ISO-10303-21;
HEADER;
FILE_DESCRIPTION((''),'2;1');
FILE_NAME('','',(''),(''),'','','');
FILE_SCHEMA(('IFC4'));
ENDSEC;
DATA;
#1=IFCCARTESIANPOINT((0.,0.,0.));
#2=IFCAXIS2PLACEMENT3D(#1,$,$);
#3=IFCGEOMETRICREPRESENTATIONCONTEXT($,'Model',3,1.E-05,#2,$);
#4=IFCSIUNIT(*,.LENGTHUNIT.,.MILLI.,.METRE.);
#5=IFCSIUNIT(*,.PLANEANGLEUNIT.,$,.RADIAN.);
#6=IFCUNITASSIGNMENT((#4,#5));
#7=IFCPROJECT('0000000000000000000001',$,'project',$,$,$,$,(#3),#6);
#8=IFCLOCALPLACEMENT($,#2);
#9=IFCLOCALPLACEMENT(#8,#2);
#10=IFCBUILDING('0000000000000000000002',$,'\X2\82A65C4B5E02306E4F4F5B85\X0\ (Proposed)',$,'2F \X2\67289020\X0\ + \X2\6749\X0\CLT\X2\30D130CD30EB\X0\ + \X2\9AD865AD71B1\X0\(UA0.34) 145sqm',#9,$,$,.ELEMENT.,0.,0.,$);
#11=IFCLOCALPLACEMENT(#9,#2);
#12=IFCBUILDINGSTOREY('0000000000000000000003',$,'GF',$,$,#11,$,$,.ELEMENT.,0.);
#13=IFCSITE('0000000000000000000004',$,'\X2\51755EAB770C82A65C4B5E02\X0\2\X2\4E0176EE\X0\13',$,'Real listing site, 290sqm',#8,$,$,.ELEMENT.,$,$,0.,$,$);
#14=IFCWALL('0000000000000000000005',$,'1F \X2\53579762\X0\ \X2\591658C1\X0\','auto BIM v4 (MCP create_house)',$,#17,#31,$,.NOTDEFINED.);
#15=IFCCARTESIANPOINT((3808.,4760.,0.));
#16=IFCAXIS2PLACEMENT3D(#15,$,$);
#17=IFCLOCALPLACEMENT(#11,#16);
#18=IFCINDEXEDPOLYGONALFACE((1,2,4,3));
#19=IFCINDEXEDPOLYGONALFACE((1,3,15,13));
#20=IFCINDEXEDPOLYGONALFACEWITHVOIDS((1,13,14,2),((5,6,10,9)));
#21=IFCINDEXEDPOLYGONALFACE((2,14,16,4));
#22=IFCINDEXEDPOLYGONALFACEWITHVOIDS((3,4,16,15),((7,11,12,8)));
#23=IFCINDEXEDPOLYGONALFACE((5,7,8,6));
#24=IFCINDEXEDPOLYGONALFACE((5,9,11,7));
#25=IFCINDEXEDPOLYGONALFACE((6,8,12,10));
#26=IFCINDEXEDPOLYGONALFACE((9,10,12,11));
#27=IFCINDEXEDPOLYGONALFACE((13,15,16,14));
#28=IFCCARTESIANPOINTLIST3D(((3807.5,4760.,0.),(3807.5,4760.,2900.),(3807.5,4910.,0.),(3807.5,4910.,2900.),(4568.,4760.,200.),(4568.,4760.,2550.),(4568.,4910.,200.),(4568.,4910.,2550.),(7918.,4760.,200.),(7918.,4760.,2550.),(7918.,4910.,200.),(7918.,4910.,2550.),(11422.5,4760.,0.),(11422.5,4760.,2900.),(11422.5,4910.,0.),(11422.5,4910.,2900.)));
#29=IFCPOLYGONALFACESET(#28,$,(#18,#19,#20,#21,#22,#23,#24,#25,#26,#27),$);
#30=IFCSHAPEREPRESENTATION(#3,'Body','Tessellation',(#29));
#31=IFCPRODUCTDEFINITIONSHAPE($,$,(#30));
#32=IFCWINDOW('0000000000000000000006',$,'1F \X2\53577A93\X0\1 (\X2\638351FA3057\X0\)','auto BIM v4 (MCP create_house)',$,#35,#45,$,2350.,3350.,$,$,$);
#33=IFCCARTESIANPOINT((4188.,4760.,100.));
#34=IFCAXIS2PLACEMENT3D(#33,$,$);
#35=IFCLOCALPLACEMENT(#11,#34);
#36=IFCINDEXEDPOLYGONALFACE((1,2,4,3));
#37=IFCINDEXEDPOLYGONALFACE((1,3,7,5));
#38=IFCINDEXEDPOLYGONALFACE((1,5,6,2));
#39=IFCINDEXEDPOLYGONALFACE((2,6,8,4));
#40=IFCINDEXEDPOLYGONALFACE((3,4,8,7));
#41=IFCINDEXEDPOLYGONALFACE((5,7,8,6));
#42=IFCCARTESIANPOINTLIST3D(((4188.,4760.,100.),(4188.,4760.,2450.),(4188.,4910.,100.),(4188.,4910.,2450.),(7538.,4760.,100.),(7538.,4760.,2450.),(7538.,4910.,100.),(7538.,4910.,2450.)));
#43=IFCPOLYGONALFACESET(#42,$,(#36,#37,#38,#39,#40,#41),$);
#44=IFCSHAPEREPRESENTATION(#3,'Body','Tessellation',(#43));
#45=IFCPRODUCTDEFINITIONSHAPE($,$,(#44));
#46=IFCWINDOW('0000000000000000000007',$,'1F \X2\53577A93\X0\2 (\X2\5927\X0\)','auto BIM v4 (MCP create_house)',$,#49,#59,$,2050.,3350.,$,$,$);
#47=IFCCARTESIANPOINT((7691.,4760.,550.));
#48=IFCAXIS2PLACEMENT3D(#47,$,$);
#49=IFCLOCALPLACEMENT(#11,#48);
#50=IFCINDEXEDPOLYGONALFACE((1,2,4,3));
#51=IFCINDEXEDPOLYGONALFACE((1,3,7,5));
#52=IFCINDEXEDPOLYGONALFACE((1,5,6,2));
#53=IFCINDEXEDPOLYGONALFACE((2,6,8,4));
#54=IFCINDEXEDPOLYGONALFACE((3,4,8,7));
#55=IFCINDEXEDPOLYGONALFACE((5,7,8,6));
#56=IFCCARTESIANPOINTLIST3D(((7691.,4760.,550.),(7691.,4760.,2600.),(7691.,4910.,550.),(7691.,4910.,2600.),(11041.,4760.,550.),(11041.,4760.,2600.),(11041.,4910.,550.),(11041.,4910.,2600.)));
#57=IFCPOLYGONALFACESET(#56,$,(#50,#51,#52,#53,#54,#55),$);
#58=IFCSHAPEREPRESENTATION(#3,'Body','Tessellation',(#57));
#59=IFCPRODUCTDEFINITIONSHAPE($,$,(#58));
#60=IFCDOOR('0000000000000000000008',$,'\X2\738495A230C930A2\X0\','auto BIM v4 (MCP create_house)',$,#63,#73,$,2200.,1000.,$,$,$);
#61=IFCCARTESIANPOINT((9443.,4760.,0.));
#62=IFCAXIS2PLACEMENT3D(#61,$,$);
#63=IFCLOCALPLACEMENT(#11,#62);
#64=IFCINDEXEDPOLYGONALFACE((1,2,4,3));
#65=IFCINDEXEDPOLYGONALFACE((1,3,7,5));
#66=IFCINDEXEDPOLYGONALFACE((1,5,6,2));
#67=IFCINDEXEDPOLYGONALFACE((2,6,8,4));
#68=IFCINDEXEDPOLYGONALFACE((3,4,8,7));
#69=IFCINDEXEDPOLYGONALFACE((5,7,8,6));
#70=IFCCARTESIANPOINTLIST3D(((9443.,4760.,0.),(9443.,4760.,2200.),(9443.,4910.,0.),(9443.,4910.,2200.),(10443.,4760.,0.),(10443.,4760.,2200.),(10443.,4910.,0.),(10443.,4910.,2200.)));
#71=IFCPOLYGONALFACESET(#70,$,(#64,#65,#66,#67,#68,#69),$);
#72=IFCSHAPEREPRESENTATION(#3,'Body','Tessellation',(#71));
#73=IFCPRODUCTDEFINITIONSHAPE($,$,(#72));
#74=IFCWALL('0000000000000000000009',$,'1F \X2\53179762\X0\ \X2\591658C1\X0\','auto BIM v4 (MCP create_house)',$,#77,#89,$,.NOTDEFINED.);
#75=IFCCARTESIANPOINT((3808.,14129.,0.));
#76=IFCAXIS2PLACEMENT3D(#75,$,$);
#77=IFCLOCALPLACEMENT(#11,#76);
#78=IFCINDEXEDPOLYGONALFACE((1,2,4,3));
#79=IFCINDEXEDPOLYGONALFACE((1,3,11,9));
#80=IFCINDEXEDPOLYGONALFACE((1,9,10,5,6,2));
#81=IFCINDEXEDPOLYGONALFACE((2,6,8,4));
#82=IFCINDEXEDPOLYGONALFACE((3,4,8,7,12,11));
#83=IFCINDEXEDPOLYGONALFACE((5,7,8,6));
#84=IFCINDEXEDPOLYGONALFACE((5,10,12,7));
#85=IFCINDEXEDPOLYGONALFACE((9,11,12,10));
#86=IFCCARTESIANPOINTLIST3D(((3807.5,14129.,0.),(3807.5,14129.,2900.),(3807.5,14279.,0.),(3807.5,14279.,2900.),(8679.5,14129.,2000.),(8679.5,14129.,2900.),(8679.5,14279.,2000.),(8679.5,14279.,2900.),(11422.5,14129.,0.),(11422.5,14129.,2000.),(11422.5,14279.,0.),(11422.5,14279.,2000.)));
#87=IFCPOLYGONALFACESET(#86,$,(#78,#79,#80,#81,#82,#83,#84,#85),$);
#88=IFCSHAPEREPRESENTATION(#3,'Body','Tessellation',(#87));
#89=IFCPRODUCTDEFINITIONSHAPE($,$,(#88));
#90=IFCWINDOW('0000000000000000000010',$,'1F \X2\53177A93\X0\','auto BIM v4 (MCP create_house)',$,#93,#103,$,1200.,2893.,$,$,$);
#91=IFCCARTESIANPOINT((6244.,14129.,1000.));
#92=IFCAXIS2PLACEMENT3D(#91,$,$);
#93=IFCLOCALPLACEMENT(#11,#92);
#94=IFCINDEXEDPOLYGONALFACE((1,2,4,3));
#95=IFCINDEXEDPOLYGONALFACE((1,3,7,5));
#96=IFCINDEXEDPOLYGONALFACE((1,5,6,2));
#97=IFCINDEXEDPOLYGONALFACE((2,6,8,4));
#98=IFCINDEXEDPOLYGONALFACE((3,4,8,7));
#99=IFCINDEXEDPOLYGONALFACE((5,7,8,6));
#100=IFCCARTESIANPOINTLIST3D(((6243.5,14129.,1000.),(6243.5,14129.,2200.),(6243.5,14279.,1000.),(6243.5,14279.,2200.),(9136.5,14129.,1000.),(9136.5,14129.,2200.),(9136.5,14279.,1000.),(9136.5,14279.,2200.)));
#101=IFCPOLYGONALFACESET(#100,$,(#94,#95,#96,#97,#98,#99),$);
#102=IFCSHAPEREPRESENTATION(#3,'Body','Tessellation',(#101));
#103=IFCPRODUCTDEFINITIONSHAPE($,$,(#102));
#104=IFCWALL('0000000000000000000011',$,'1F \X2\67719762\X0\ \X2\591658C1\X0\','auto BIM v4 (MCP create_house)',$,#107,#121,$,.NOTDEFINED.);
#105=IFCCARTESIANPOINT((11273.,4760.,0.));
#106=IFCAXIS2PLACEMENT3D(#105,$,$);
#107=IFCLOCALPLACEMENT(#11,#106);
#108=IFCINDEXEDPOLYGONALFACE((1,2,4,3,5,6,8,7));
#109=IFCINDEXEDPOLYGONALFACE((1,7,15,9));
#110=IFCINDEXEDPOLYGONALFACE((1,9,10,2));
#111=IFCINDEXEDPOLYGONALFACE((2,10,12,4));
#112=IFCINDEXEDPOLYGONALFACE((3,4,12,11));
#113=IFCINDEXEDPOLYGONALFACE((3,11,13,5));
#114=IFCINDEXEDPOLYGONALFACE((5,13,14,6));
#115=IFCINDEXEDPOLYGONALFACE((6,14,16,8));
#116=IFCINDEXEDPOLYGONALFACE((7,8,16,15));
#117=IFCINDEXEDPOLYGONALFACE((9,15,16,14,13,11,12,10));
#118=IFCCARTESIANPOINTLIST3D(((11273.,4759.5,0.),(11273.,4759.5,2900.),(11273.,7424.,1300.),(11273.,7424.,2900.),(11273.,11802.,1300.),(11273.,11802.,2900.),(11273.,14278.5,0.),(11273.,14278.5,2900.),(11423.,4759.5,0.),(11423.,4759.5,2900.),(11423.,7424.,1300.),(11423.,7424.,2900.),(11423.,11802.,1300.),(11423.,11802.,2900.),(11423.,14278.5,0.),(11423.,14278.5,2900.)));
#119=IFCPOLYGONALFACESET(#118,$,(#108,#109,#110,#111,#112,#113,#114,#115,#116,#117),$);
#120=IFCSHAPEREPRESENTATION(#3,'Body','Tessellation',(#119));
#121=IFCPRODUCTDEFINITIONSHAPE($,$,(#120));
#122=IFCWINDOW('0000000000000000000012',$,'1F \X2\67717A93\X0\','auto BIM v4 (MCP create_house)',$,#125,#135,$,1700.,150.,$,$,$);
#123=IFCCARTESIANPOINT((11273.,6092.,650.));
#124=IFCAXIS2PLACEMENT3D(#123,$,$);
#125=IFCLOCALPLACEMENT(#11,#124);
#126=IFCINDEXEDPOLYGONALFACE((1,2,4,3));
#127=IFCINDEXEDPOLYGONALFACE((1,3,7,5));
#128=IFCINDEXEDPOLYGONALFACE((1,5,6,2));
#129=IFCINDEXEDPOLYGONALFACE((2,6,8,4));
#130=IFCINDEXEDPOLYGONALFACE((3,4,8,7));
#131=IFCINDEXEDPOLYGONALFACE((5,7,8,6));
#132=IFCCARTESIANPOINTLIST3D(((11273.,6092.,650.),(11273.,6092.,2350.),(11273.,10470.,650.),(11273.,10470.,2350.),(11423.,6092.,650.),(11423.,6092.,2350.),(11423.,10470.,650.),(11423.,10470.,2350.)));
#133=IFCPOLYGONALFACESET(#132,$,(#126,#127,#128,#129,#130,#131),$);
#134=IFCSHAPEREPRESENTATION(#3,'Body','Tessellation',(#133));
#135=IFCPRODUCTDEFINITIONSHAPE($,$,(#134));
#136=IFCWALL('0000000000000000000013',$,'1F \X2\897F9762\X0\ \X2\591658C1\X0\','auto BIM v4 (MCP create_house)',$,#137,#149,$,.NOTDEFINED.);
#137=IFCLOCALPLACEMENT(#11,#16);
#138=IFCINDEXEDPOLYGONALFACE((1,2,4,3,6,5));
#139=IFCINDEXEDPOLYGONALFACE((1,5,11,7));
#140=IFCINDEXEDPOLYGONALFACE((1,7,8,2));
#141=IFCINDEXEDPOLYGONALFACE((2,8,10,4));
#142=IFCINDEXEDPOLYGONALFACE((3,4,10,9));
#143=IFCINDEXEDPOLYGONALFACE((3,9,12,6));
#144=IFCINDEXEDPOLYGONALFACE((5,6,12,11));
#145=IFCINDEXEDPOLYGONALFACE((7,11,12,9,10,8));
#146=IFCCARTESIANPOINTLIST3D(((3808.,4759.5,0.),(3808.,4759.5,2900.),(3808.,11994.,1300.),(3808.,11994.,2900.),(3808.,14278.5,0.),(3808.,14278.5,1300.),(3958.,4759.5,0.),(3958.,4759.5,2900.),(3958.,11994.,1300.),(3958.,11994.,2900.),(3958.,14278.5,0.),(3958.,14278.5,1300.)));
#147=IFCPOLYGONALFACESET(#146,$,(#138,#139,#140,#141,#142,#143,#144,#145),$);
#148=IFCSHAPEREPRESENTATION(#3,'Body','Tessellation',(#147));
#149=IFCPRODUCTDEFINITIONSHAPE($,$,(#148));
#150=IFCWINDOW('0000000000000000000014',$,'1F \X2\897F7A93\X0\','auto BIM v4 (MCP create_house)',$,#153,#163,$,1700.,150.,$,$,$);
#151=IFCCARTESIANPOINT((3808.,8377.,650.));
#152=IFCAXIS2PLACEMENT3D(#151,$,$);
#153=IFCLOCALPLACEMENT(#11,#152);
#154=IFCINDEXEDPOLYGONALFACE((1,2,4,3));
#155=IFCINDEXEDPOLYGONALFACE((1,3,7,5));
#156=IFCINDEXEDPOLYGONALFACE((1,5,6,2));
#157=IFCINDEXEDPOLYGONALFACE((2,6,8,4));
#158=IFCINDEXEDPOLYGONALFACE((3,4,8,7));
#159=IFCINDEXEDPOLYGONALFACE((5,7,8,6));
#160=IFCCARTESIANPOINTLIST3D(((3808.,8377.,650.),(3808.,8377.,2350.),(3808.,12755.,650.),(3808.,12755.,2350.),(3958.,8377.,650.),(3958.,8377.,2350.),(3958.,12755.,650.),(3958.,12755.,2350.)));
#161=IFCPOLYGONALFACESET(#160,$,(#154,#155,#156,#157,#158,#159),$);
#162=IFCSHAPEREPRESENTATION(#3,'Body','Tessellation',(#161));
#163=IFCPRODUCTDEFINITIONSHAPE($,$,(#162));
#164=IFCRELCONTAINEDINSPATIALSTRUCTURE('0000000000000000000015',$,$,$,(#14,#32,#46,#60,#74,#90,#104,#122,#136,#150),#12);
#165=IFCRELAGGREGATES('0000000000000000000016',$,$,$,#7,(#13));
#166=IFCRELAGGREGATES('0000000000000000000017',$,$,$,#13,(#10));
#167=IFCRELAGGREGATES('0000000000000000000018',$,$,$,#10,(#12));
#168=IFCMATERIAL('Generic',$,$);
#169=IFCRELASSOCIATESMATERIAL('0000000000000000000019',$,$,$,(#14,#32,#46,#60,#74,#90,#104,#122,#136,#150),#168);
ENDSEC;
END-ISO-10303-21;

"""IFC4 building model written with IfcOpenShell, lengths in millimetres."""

from ifc_helpers import new_model, si_unit, frame, frame_2d, origin, place, context, project, spatial, rectangle, extrude, material, element, fill, save


model = new_model("IFC4")

# Units and contexts
model_context = context("Model", 3, precision=1e-05, world=origin())
ifc_project = project(units=[si_unit("LENGTHUNIT", "METRE", prefix="MILLI"), si_unit("PLANEANGLEUNIT", "RADIAN")], contexts=[model_context])

# Site, building, storey
site_placement = place(None, origin())
site = spatial("IfcSite", under=ifc_project, at=site_placement, Name="兵庫県芦屋市2丁目13", ObjectType="Real listing site, 290sqm", CompositionType="ELEMENT", RefElevation=0.0)
building_placement = place(site_placement, origin())
building = spatial("IfcBuilding", under=site, at=building_placement, Name="芦屋市の住宅 (Proposed)", ObjectType="2F 木造 + 杉CLTパネル + 高断熱(UA0.34) 145sqm", CompositionType="ELEMENT", ElevationOfRefHeight=0.0, ElevationOfTerrain=0.0)
storey_placement = place(building_placement, origin())
storey = spatial("IfcBuildingStorey", under=building, at=storey_placement, Name="GF", CompositionType="ELEMENT", Elevation=0.0)

# Shared definitions
ifc_material = material(Name="Generic")

# Wall, openings, windows, door
wall_1_placement = place(storey_placement, frame((3808.0, 4760.0, 0.0)))
wall_1 = element("IfcWall", 1, at=wall_1_placement, inside=storey, material=ifc_material, Name="1F 南面 外壁", Description="auto BIM v4 (MCP create_house)", PredefinedType="NOTDEFINED", context=model_context, shape_type="SweptSolid", body=[
    extrude(rectangle(XDim=7615.0, YDim=150.0, at=frame_2d((3807.0, 75.0))), frame((3808.0, 4760.0, 0.0)), (0.0, 0.0, 1.0), 2900.0),
])
opening_1_placement = place(storey_placement, frame((4188.0, 4760.0, 100.0)))
opening_1 = element("IfcOpeningElement", 2, at=opening_1_placement, cuts=wall_1, PredefinedType="NOTDEFINED", context=model_context, shape_type="SweptSolid", body=[
    extrude(rectangle(XDim=3350.0, YDim=150.0, at=frame_2d((1675.0, 75.0))), frame((4188.0, 4760.0, 100.0)), (0.0, 0.0, 1.0), 2350.0),
])
opening_2_placement = place(storey_placement, frame((7691.0, 4760.0, 550.0)))
opening_2 = element("IfcOpeningElement", 3, at=opening_2_placement, cuts=wall_1, PredefinedType="NOTDEFINED", context=model_context, shape_type="SweptSolid", body=[
    extrude(rectangle(XDim=3350.0, YDim=150.0, at=frame_2d((1675.0, 75.0))), frame((7691.0, 4760.0, 550.0)), (0.0, 0.0, 1.0), 2050.0),
])
opening_3_placement = place(storey_placement, frame((9443.0, 4760.0, 0.0)))
opening_3 = element("IfcOpeningElement", 4, at=opening_3_placement, cuts=wall_1, PredefinedType="NOTDEFINED", context=model_context, shape_type="SweptSolid", body=[
    extrude(rectangle(XDim=1000.0, YDim=150.0, at=frame_2d((500.0, 75.0))), frame((9443.0, 4760.0, 0.0)), (0.0, 0.0, 1.0), 2200.0),
])
window_1_placement = place(storey_placement, frame((4188.0, 4760.0, 100.0)))
window_1 = element("IfcWindow", 5, at=window_1_placement, inside=storey, material=ifc_material, Name="1F 南窓1 (掃出し)", Description="auto BIM v4 (MCP create_house)", OverallHeight=2350.0, OverallWidth=3350.0, context=model_context, shape_type="SweptSolid", body=[
    extrude(rectangle(XDim=3350.0, YDim=150.0, at=frame_2d((1675.0, 75.0))), frame((4188.0, 4760.0, 100.0)), (0.0, 0.0, 1.0), 2350.0),
])
fill(opening_1, window_1)
window_2_placement = place(storey_placement, frame((7691.0, 4760.0, 550.0)))
window_2 = element("IfcWindow", 6, at=window_2_placement, inside=storey, material=ifc_material, Name="1F 南窓2 (大)", Description="auto BIM v4 (MCP create_house)", OverallHeight=2050.0, OverallWidth=3350.0, context=model_context, shape_type="SweptSolid", body=[
    extrude(rectangle(XDim=3350.0, YDim=150.0, at=frame_2d((1675.0, 75.0))), frame((7691.0, 4760.0, 550.0)), (0.0, 0.0, 1.0), 2050.0),
])
fill(opening_2, window_2)
door_1_placement = place(storey_placement, frame((9443.0, 4760.0, 0.0)))
door_1 = element("IfcDoor", 7, at=door_1_placement, inside=storey, material=ifc_material, Name="玄関ドア", Description="auto BIM v4 (MCP create_house)", OverallHeight=2200.0, OverallWidth=1000.0, context=model_context, shape_type="SweptSolid", body=[
    extrude(rectangle(XDim=1000.0, YDim=150.0, at=frame_2d((500.0, 75.0))), frame((9443.0, 4760.0, 0.0)), (0.0, 0.0, 1.0), 2200.0),
])
fill(opening_3, door_1)

# Walls, openings, windows
wall_2_placement = place(storey_placement, frame((3808.0, 14129.0, 0.0)))
wall_2 = element("IfcWall", 8, at=wall_2_placement, inside=storey, material=ifc_material, Name="1F 北面 外壁", Description="auto BIM v4 (MCP create_house)", PredefinedType="NOTDEFINED", context=model_context, shape_type="SweptSolid", body=[
    extrude(rectangle(XDim=7615.0, YDim=150.0, at=frame_2d((3807.0, 75.0))), frame((3808.0, 14129.0, 0.0)), (0.0, 0.0, 1.0), 2900.0),
])
opening_4_placement = place(storey_placement, frame((6244.0, 14129.0, 1000.0)))
opening_4 = element("IfcOpeningElement", 9, at=opening_4_placement, cuts=wall_2, PredefinedType="NOTDEFINED", context=model_context, shape_type="SweptSolid", body=[
    extrude(rectangle(XDim=2893.0, YDim=150.0, at=frame_2d((1446.0, 75.0))), frame((6244.0, 14129.0, 1000.0)), (0.0, 0.0, 1.0), 1200.0),
])
window_3_placement = place(storey_placement, frame((6244.0, 14129.0, 1000.0)))
window_3 = element("IfcWindow", 10, at=window_3_placement, inside=storey, material=ifc_material, Name="1F 北窓", Description="auto BIM v4 (MCP create_house)", OverallHeight=1200.0, OverallWidth=2893.0, context=model_context, shape_type="SweptSolid", body=[
    extrude(rectangle(XDim=2893.0, YDim=150.0, at=frame_2d((1446.0, 75.0))), frame((6244.0, 14129.0, 1000.0)), (0.0, 0.0, 1.0), 1200.0),
])
fill(opening_4, window_3)
wall_3_placement = place(storey_placement, frame((11273.0, 4760.0, 0.0)))
wall_3 = element("IfcWall", 11, at=wall_3_placement, inside=storey, material=ifc_material, Name="1F 東面 外壁", Description="auto BIM v4 (MCP create_house)", PredefinedType="NOTDEFINED", context=model_context, shape_type="SweptSolid", body=[
    extrude(rectangle(XDim=150.0, YDim=9519.0, at=frame_2d((75.0, 4759.0))), frame((11273.0, 4760.0, 0.0)), (0.0, 0.0, 1.0), 2900.0),
])
opening_5_placement = place(storey_placement, frame((11273.0, 6092.0, 650.0)))
opening_5 = element("IfcOpeningElement", 12, at=opening_5_placement, cuts=wall_3, PredefinedType="NOTDEFINED", context=model_context, shape_type="SweptSolid", body=[
    extrude(rectangle(XDim=150.0, YDim=4378.0, at=frame_2d((75.0, 2189.0))), frame((11273.0, 6092.0, 650.0)), (0.0, 0.0, 1.0), 1700.0),
])
window_4_placement = place(storey_placement, frame((11273.0, 6092.0, 650.0)))
window_4 = element("IfcWindow", 13, at=window_4_placement, inside=storey, material=ifc_material, Name="1F 東窓", Description="auto BIM v4 (MCP create_house)", OverallHeight=1700.0, OverallWidth=150.0, context=model_context, shape_type="SweptSolid", body=[
    extrude(rectangle(XDim=150.0, YDim=4378.0, at=frame_2d((75.0, 2189.0))), frame((11273.0, 6092.0, 650.0)), (0.0, 0.0, 1.0), 1700.0),
])
fill(opening_5, window_4)
wall_4_placement = place(storey_placement, frame((3808.0, 4760.0, 0.0)))
wall_4 = element("IfcWall", 14, at=wall_4_placement, inside=storey, material=ifc_material, Name="1F 西面 外壁", Description="auto BIM v4 (MCP create_house)", PredefinedType="NOTDEFINED", context=model_context, shape_type="SweptSolid", body=[
    extrude(rectangle(XDim=150.0, YDim=9519.0, at=frame_2d((75.0, 4759.0))), frame((3808.0, 4760.0, 0.0)), (0.0, 0.0, 1.0), 2900.0),
])
opening_6_placement = place(storey_placement, frame((3808.0, 8377.0, 650.0)))
opening_6 = element("IfcOpeningElement", 15, at=opening_6_placement, cuts=wall_4, PredefinedType="NOTDEFINED", context=model_context, shape_type="SweptSolid", body=[
    extrude(rectangle(XDim=150.0, YDim=4378.0, at=frame_2d((75.0, 2189.0))), frame((3808.0, 8377.0, 650.0)), (0.0, 0.0, 1.0), 1700.0),
])
window_5_placement = place(storey_placement, frame((3808.0, 8377.0, 650.0)))
window_5 = element("IfcWindow", 16, at=window_5_placement, inside=storey, material=ifc_material, Name="1F 西窓", Description="auto BIM v4 (MCP create_house)", OverallHeight=1700.0, OverallWidth=150.0, context=model_context, shape_type="SweptSolid", body=[
    extrude(rectangle(XDim=150.0, YDim=4378.0, at=frame_2d((75.0, 2189.0))), frame((3808.0, 8377.0, 650.0)), (0.0, 0.0, 1.0), 1700.0),
])
fill(opening_6, window_5)

save(model, "model.ifc")
